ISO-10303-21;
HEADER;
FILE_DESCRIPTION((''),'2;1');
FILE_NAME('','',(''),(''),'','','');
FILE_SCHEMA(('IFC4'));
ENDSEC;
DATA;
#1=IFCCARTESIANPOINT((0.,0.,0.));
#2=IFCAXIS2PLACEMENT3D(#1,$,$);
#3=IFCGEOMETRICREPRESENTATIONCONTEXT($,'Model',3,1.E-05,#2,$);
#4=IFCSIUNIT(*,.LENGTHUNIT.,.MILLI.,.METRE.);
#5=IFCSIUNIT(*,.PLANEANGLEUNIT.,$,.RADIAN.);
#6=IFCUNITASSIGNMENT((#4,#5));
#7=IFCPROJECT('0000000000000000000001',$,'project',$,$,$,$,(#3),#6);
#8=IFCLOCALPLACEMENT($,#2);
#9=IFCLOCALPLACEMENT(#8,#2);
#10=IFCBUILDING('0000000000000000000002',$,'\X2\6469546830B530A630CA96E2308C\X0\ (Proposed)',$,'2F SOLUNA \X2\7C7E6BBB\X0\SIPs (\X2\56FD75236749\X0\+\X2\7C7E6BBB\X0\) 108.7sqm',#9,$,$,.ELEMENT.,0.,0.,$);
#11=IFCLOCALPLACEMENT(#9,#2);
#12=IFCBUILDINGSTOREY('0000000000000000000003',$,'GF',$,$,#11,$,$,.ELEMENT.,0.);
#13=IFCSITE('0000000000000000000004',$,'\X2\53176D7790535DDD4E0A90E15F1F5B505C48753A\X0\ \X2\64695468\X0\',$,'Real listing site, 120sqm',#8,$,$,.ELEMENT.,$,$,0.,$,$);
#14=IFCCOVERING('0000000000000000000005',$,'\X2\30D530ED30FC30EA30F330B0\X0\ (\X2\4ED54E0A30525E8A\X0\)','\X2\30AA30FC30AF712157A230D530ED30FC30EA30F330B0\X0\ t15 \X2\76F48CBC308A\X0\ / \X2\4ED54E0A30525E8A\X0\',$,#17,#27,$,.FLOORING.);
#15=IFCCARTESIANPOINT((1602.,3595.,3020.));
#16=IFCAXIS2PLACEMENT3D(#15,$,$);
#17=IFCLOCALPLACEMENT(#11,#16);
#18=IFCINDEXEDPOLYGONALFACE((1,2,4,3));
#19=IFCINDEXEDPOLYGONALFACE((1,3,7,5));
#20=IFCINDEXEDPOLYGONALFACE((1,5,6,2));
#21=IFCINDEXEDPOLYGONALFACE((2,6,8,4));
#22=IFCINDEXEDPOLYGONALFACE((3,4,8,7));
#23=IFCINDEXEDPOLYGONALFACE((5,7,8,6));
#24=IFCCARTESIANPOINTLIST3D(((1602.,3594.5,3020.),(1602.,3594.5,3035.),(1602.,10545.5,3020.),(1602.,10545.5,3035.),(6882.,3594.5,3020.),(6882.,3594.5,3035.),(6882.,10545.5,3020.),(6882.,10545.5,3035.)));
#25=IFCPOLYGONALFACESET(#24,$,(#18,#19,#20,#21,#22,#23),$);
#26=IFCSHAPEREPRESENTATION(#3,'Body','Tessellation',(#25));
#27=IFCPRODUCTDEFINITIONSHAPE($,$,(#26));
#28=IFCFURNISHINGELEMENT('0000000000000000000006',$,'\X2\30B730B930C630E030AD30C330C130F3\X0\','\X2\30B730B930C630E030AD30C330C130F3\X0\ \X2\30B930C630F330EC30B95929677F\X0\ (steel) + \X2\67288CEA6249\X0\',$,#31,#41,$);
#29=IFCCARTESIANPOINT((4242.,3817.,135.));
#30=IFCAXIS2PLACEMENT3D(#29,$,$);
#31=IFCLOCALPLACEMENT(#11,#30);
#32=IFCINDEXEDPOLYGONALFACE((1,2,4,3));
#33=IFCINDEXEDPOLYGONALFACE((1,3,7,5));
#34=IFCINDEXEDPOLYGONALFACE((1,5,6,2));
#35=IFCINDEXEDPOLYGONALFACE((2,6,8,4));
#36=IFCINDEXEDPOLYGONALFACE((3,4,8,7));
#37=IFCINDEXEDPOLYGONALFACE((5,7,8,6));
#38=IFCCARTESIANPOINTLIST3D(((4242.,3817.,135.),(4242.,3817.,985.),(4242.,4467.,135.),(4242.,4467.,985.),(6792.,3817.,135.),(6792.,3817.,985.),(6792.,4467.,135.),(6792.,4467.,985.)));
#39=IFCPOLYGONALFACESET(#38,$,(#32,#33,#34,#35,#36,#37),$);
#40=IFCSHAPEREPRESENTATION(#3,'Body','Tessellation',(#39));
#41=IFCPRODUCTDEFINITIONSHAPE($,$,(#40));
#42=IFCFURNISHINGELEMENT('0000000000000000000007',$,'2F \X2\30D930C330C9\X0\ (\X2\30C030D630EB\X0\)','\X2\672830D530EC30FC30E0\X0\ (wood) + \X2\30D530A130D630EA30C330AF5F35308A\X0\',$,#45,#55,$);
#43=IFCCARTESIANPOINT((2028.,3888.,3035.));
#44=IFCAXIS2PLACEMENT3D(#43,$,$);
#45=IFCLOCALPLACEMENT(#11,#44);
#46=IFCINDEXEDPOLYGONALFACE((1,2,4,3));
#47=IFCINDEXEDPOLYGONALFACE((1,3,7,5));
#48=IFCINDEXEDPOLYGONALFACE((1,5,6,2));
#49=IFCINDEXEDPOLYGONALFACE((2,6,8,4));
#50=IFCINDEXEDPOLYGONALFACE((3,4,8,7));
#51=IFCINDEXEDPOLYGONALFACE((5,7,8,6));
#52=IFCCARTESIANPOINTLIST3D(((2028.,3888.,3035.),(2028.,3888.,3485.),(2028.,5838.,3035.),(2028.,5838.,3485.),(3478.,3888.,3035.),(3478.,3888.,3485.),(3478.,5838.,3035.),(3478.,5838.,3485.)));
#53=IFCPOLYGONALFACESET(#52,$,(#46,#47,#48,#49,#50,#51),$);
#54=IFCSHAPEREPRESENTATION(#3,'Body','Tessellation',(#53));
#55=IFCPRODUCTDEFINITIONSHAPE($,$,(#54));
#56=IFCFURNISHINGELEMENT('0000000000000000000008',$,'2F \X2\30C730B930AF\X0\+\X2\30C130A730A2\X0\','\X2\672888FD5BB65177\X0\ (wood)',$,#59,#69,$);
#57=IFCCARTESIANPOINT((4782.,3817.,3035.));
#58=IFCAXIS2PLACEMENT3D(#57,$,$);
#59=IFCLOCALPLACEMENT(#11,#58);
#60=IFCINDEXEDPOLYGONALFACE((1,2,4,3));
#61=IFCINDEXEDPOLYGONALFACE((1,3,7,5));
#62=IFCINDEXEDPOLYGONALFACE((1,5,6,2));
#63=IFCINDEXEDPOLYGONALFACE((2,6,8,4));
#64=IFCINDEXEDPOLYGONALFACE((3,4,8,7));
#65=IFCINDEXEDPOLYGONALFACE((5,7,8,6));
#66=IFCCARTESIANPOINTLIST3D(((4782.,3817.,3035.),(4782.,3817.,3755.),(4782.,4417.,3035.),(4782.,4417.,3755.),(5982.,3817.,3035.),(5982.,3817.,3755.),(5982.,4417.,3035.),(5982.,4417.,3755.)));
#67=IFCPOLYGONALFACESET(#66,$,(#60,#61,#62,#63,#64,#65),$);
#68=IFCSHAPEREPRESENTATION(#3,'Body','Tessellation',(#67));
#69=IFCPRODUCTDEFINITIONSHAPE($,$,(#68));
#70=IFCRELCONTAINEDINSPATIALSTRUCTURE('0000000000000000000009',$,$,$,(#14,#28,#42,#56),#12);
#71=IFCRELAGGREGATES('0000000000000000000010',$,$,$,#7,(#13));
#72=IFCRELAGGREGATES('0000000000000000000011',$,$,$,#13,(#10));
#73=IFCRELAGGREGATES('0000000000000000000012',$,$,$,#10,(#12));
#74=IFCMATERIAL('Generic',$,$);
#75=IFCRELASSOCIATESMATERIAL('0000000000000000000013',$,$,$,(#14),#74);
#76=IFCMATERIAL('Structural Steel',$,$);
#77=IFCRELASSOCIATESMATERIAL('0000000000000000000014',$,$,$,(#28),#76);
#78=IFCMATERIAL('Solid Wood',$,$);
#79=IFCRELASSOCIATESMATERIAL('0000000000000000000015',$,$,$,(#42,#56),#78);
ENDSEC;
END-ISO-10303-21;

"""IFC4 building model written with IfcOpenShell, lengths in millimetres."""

from ifc_helpers import new_model, si_unit, frame, frame_2d, origin, place, context, project, spatial, rectangle, extrude, material, element, save


model = new_model("IFC4")

# Units and contexts
model_context = context("Model", 3, precision=1e-05, world=origin())
ifc_project = project(units=[si_unit("LENGTHUNIT", "METRE", prefix="MILLI"), si_unit("PLANEANGLEUNIT", "RADIAN")], contexts=[model_context])

# Site, building, storey
site_placement = place(None, origin())
site = spatial("IfcSite", under=ifc_project, at=site_placement, Name="北海道川上郡弟子屈町 摩周", ObjectType="Real listing site, 120sqm", CompositionType="ELEMENT", RefElevation=0.0)
building_placement = place(site_placement, origin())
building = spatial("IfcBuilding", under=site, at=building_placement, Name="摩周サウナ離れ (Proposed)", ObjectType="2F SOLUNA 籾殻SIPs (国産杉+籾殻) 108.7sqm", CompositionType="ELEMENT", ElevationOfRefHeight=0.0, ElevationOfTerrain=0.0)
storey_placement = place(building_placement, origin())
storey = spatial("IfcBuildingStorey", under=building, at=storey_placement, Name="GF", CompositionType="ELEMENT", Elevation=0.0)

# Shared definitions
ifc_material_1 = material(Name="Solid Wood")

# Shared definitions
ifc_material_2 = material(Name="Generic")

# Shared definitions
ifc_material_3 = material(Name="Structural Steel")

# Covering
covering_placement = place(storey_placement, frame((1602.0, 3595.0, 3020.0)))
element("IfcCovering", 1, at=covering_placement, inside=storey, material=ifc_material_2, Name="フローリング (仕上げ床)", Description="オーク無垢フローリング t15 直貼り / 仕上げ床", PredefinedType="FLOORING", context=model_context, shape_type="SweptSolid", body=[
    extrude(rectangle(XDim=5280.0, YDim=6951.0, at=frame_2d((2640.0, 3475.0))), frame((1602.0, 3595.0, 3020.0)), (0.0, 0.0, 1.0), 15.0),
])

# Furnishing elements
furnishing_1_placement = place(storey_placement, frame((4242.0, 3817.0, 135.0)))
element("IfcFurnishingElement", 2, at=furnishing_1_placement, inside=storey, material=ifc_material_3, Name="システムキッチン", Description="システムキッチン ステンレス天板 (steel) + 木質扉", context=model_context, shape_type="SweptSolid", body=[
    extrude(rectangle(XDim=2550.0, YDim=650.0, at=frame_2d((1275.0, 325.0))), frame((4242.0, 3817.0, 135.0)), (0.0, 0.0, 1.0), 850.0),
])
furnishing_2_placement = place(storey_placement, frame((2028.0, 3888.0, 3035.0)))
element("IfcFurnishingElement", 3, at=furnishing_2_placement, inside=storey, material=ifc_material_1, Name="2F ベッド (ダブル)", Description="木フレーム (wood) + ファブリック張り", context=model_context, shape_type="SweptSolid", body=[
    extrude(rectangle(XDim=1450.0, YDim=1950.0, at=frame_2d((725.0, 975.0))), frame((2028.0, 3888.0, 3035.0)), (0.0, 0.0, 1.0), 450.0),
])
furnishing_3_placement = place(storey_placement, frame((4782.0, 3817.0, 3035.0)))
element("IfcFurnishingElement", 4, at=furnishing_3_placement, inside=storey, material=ifc_material_1, Name="2F デスク+チェア", Description="木製家具 (wood)", context=model_context, shape_type="SweptSolid", body=[
    extrude(rectangle(XDim=1200.0, YDim=600.0, at=frame_2d((600.0, 300.0))), frame((4782.0, 3817.0, 3035.0)), (0.0, 0.0, 1.0), 720.0),
])

save(model, "model.ifc")
